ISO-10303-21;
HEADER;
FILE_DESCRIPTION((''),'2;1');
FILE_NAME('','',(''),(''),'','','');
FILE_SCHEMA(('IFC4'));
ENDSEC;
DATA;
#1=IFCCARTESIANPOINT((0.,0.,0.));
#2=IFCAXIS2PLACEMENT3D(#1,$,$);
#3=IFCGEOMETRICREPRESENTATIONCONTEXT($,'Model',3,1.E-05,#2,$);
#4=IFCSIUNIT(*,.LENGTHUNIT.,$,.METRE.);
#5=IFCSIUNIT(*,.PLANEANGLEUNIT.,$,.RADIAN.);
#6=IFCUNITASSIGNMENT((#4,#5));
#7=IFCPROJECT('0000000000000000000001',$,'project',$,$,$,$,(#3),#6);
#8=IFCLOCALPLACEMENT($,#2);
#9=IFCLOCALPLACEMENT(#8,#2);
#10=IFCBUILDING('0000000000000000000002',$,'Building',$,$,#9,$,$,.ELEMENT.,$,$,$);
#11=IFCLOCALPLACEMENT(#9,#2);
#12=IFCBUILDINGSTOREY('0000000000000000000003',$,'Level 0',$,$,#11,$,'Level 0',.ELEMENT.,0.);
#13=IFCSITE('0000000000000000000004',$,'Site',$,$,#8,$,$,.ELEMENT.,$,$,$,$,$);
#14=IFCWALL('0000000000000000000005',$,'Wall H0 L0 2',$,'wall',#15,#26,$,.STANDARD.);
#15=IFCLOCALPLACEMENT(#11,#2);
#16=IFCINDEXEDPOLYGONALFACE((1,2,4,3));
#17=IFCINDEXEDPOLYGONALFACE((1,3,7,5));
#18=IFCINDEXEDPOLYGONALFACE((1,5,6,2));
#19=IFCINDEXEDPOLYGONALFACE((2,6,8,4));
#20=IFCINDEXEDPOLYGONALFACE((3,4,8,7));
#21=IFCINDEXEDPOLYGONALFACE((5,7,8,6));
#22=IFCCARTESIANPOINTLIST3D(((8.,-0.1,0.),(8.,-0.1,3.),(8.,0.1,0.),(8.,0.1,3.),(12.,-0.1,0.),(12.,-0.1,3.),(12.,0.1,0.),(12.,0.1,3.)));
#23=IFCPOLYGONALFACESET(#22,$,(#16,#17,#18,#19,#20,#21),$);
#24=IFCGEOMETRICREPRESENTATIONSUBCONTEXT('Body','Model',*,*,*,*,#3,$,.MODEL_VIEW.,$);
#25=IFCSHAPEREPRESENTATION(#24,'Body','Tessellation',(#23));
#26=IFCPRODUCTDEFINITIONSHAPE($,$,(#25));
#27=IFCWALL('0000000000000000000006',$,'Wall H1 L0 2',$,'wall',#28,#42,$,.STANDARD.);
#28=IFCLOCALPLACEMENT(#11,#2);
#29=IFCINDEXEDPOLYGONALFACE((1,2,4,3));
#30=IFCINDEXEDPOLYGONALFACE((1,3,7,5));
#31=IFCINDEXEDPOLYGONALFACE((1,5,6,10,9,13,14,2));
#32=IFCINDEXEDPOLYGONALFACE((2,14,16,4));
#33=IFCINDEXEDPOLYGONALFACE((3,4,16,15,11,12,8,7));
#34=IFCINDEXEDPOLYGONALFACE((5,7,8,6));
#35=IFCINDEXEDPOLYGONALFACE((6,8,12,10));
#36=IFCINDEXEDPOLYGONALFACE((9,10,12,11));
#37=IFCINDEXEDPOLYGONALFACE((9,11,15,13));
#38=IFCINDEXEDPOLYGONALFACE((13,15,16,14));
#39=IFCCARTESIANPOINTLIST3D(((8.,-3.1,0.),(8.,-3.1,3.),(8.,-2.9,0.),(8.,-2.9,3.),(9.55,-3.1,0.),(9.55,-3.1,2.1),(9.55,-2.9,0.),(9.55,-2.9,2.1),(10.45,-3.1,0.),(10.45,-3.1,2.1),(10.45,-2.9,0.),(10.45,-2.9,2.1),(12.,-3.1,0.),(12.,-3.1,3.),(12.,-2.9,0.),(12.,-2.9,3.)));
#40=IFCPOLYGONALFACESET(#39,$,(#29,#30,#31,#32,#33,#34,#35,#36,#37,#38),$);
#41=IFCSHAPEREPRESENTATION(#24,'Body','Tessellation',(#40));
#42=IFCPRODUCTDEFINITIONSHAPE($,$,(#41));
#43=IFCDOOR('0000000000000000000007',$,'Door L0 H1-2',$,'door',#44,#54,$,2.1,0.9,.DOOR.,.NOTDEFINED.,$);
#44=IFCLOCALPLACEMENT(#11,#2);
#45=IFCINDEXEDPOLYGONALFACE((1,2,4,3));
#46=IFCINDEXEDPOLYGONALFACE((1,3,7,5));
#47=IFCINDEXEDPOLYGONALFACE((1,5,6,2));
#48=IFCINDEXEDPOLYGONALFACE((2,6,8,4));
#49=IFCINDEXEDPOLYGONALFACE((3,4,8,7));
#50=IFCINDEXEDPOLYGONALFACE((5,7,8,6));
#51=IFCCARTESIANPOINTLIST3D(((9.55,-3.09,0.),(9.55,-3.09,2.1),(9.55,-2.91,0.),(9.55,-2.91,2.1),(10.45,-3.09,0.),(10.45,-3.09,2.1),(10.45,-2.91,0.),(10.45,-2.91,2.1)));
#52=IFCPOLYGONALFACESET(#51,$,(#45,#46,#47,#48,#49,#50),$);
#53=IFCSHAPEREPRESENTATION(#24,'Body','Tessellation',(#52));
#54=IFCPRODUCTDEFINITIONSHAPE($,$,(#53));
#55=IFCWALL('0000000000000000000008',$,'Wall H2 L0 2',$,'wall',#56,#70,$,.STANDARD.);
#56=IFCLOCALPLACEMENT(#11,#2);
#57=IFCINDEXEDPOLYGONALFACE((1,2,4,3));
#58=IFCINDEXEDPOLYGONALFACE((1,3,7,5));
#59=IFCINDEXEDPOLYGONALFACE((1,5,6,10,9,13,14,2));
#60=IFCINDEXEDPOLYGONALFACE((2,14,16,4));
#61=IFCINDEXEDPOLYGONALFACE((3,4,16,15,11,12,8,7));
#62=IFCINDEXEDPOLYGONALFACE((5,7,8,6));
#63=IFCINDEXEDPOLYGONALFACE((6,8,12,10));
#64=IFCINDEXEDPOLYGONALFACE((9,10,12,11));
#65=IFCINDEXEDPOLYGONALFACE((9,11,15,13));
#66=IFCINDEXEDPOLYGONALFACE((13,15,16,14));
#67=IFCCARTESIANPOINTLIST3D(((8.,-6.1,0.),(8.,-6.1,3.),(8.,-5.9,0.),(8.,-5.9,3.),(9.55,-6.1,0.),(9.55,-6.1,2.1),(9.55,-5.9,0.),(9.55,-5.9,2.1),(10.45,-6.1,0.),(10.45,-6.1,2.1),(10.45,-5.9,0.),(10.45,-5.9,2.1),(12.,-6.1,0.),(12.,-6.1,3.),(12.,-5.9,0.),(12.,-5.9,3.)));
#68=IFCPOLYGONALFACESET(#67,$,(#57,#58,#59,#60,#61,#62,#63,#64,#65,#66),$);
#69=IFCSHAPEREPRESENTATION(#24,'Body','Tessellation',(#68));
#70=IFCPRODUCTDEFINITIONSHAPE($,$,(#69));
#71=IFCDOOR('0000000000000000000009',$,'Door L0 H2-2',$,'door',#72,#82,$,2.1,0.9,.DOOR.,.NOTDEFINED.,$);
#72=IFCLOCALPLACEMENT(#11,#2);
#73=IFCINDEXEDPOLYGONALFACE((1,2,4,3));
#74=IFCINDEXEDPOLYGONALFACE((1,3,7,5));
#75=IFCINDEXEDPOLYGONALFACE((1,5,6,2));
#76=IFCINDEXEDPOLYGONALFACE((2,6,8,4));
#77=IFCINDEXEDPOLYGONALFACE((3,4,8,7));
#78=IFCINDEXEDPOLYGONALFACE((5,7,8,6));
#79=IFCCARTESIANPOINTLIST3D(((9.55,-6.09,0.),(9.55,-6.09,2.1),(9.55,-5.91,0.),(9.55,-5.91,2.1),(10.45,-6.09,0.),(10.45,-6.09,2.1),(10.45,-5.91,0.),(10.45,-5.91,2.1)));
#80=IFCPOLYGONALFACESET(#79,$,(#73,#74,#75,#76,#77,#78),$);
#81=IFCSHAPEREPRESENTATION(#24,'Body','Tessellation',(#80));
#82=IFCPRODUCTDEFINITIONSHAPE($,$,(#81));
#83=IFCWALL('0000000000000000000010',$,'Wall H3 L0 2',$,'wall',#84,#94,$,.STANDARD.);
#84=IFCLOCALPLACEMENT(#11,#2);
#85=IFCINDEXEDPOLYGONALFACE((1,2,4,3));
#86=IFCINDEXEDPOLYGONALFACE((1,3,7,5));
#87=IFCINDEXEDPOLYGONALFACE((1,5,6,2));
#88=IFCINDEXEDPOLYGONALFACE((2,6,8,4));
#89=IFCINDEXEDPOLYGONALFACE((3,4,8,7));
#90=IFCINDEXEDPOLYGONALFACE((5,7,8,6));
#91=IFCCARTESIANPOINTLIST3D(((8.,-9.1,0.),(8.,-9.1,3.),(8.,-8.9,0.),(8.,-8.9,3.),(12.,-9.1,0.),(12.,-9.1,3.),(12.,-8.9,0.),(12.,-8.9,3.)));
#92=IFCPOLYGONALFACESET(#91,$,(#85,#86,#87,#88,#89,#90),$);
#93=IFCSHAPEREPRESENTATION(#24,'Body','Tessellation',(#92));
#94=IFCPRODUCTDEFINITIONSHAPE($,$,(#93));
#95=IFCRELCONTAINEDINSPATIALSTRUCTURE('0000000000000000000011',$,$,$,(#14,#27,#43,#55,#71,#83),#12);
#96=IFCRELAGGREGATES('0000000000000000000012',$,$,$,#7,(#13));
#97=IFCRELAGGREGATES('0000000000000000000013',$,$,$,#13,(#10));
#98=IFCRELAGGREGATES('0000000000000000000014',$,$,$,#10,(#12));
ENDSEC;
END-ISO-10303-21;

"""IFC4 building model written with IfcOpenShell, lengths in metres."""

from ifc_helpers import new_model, si_unit, frame, frame_2d, origin, origin_2d, place, context, subcontext, project, spatial, rectangle, extrude, element, fill, save


model = new_model("IFC4")

# Units and contexts
model_context = context("Model", 3, precision=1e-05, world=origin())
body_context = subcontext(model_context, "Body", "Model", "MODEL_VIEW")
ifc_project = project(units=[si_unit("LENGTHUNIT", "METRE"), si_unit("PLANEANGLEUNIT", "RADIAN")], contexts=[model_context])

# Site, building, storey
site_placement = place(None, origin())
site = spatial("IfcSite", under=ifc_project, at=site_placement, Name="Site", CompositionType="ELEMENT")
building_placement = place(site_placement, origin())
building = spatial("IfcBuilding", under=site, at=building_placement, Name="Building", CompositionType="ELEMENT")
storey_placement = place(building_placement, origin())
storey = spatial("IfcBuildingStorey", under=building, at=storey_placement, Name="Level 0", LongName="Level 0", CompositionType="ELEMENT", Elevation=0.0)

# Wall
wall_1_placement = place(storey_placement, frame((8.0, 0.0, 0.0), z_axis=(0.0, 0.0, 1.0), x_axis=(1.0, 0.0, 0.0)))
element("IfcWall", 1, at=wall_1_placement, inside=storey, Name="Wall H0 L0 2", ObjectType="wall", PredefinedType="STANDARD", context=body_context, shape_type="SweptSolid", body=[
    extrude(rectangle(XDim=4.0, YDim=0.2, at=frame_2d((2.0, 0.0))), origin(), (0.0, 0.0, 1.0), 3.0),
])

# Walls, openings, doors
wall_2_placement = place(storey_placement, frame((8.0, -3.0, 0.0), z_axis=(0.0, 0.0, 1.0), x_axis=(1.0, 0.0, 0.0)))
wall_2 = element("IfcWall", 2, at=wall_2_placement, inside=storey, Name="Wall H1 L0 2", ObjectType="wall", PredefinedType="STANDARD", context=body_context, shape_type="SweptSolid", body=[
    extrude(rectangle(XDim=4.0, YDim=0.2, at=frame_2d((2.0, 0.0))), origin(), (0.0, 0.0, 1.0), 3.0),
])
opening_1_placement = place(storey_placement, frame((10.0, -3.0, 0.0), z_axis=(0.0, 0.0, 1.0), x_axis=(1.0, 0.0, 0.0)))
opening_1 = element("IfcOpeningElement", 3, at=opening_1_placement, cuts=wall_2, ObjectType="Opening", PredefinedType="OPENING", context=body_context, shape_type="SweptSolid", body=[
    extrude(rectangle(XDim=0.9, YDim=0.22, at=origin_2d()), origin(), (0.0, 0.0, 1.0), 2.1),
])
door_1_placement = place(storey_placement, frame((10.0, -3.0, 0.0), z_axis=(0.0, 0.0, 1.0), x_axis=(1.0, 0.0, 0.0)))
door_1 = element("IfcDoor", 4, at=door_1_placement, inside=storey, Name="Door L0 H1-2", ObjectType="door", OperationType="NOTDEFINED", OverallHeight=2.1, OverallWidth=0.9, PredefinedType="DOOR", context=body_context, shape_type="SweptSolid", body=[
    extrude(rectangle(XDim=0.9, YDim=0.18, at=origin_2d()), origin(), (0.0, 0.0, 1.0), 2.1),
])
fill(opening_1, door_1)
wall_3_placement = place(storey_placement, frame((8.0, -6.0, 0.0), z_axis=(0.0, 0.0, 1.0), x_axis=(1.0, 0.0, 0.0)))
wall_3 = element("IfcWall", 5, at=wall_3_placement, inside=storey, Name="Wall H2 L0 2", ObjectType="wall", PredefinedType="STANDARD", context=body_context, shape_type="SweptSolid", body=[
    extrude(rectangle(XDim=4.0, YDim=0.2, at=frame_2d((2.0, 0.0))), origin(), (0.0, 0.0, 1.0), 3.0),
])
opening_2_placement = place(storey_placement, frame((10.0, -6.0, 0.0), z_axis=(0.0, 0.0, 1.0), x_axis=(1.0, 0.0, 0.0)))
opening_2 = element("IfcOpeningElement", 6, at=opening_2_placement, cuts=wall_3, ObjectType="Opening", PredefinedType="OPENING", context=body_context, shape_type="SweptSolid", body=[
    extrude(rectangle(XDim=0.9, YDim=0.22, at=origin_2d()), origin(), (0.0, 0.0, 1.0), 2.1),
])
door_2_placement = place(storey_placement, frame((10.0, -6.0, 0.0), z_axis=(0.0, 0.0, 1.0), x_axis=(1.0, 0.0, 0.0)))
door_2 = element("IfcDoor", 7, at=door_2_placement, inside=storey, Name="Door L0 H2-2", ObjectType="door", OperationType="NOTDEFINED", OverallHeight=2.1, OverallWidth=0.9, PredefinedType="DOOR", context=body_context, shape_type="SweptSolid", body=[
    extrude(rectangle(XDim=0.9, YDim=0.18, at=origin_2d()), origin(), (0.0, 0.0, 1.0), 2.1),
])
fill(opening_2, door_2)

# Wall
wall_4_placement = place(storey_placement, frame((8.0, -9.0, 0.0), z_axis=(0.0, 0.0, 1.0), x_axis=(1.0, 0.0, 0.0)))
element("IfcWall", 8, at=wall_4_placement, inside=storey, Name="Wall H3 L0 2", ObjectType="wall", PredefinedType="STANDARD", context=body_context, shape_type="SweptSolid", body=[
    extrude(rectangle(XDim=4.0, YDim=0.2, at=frame_2d((2.0, 0.0))), origin(), (0.0, 0.0, 1.0), 3.0),
])

save(model, "model.ifc")
